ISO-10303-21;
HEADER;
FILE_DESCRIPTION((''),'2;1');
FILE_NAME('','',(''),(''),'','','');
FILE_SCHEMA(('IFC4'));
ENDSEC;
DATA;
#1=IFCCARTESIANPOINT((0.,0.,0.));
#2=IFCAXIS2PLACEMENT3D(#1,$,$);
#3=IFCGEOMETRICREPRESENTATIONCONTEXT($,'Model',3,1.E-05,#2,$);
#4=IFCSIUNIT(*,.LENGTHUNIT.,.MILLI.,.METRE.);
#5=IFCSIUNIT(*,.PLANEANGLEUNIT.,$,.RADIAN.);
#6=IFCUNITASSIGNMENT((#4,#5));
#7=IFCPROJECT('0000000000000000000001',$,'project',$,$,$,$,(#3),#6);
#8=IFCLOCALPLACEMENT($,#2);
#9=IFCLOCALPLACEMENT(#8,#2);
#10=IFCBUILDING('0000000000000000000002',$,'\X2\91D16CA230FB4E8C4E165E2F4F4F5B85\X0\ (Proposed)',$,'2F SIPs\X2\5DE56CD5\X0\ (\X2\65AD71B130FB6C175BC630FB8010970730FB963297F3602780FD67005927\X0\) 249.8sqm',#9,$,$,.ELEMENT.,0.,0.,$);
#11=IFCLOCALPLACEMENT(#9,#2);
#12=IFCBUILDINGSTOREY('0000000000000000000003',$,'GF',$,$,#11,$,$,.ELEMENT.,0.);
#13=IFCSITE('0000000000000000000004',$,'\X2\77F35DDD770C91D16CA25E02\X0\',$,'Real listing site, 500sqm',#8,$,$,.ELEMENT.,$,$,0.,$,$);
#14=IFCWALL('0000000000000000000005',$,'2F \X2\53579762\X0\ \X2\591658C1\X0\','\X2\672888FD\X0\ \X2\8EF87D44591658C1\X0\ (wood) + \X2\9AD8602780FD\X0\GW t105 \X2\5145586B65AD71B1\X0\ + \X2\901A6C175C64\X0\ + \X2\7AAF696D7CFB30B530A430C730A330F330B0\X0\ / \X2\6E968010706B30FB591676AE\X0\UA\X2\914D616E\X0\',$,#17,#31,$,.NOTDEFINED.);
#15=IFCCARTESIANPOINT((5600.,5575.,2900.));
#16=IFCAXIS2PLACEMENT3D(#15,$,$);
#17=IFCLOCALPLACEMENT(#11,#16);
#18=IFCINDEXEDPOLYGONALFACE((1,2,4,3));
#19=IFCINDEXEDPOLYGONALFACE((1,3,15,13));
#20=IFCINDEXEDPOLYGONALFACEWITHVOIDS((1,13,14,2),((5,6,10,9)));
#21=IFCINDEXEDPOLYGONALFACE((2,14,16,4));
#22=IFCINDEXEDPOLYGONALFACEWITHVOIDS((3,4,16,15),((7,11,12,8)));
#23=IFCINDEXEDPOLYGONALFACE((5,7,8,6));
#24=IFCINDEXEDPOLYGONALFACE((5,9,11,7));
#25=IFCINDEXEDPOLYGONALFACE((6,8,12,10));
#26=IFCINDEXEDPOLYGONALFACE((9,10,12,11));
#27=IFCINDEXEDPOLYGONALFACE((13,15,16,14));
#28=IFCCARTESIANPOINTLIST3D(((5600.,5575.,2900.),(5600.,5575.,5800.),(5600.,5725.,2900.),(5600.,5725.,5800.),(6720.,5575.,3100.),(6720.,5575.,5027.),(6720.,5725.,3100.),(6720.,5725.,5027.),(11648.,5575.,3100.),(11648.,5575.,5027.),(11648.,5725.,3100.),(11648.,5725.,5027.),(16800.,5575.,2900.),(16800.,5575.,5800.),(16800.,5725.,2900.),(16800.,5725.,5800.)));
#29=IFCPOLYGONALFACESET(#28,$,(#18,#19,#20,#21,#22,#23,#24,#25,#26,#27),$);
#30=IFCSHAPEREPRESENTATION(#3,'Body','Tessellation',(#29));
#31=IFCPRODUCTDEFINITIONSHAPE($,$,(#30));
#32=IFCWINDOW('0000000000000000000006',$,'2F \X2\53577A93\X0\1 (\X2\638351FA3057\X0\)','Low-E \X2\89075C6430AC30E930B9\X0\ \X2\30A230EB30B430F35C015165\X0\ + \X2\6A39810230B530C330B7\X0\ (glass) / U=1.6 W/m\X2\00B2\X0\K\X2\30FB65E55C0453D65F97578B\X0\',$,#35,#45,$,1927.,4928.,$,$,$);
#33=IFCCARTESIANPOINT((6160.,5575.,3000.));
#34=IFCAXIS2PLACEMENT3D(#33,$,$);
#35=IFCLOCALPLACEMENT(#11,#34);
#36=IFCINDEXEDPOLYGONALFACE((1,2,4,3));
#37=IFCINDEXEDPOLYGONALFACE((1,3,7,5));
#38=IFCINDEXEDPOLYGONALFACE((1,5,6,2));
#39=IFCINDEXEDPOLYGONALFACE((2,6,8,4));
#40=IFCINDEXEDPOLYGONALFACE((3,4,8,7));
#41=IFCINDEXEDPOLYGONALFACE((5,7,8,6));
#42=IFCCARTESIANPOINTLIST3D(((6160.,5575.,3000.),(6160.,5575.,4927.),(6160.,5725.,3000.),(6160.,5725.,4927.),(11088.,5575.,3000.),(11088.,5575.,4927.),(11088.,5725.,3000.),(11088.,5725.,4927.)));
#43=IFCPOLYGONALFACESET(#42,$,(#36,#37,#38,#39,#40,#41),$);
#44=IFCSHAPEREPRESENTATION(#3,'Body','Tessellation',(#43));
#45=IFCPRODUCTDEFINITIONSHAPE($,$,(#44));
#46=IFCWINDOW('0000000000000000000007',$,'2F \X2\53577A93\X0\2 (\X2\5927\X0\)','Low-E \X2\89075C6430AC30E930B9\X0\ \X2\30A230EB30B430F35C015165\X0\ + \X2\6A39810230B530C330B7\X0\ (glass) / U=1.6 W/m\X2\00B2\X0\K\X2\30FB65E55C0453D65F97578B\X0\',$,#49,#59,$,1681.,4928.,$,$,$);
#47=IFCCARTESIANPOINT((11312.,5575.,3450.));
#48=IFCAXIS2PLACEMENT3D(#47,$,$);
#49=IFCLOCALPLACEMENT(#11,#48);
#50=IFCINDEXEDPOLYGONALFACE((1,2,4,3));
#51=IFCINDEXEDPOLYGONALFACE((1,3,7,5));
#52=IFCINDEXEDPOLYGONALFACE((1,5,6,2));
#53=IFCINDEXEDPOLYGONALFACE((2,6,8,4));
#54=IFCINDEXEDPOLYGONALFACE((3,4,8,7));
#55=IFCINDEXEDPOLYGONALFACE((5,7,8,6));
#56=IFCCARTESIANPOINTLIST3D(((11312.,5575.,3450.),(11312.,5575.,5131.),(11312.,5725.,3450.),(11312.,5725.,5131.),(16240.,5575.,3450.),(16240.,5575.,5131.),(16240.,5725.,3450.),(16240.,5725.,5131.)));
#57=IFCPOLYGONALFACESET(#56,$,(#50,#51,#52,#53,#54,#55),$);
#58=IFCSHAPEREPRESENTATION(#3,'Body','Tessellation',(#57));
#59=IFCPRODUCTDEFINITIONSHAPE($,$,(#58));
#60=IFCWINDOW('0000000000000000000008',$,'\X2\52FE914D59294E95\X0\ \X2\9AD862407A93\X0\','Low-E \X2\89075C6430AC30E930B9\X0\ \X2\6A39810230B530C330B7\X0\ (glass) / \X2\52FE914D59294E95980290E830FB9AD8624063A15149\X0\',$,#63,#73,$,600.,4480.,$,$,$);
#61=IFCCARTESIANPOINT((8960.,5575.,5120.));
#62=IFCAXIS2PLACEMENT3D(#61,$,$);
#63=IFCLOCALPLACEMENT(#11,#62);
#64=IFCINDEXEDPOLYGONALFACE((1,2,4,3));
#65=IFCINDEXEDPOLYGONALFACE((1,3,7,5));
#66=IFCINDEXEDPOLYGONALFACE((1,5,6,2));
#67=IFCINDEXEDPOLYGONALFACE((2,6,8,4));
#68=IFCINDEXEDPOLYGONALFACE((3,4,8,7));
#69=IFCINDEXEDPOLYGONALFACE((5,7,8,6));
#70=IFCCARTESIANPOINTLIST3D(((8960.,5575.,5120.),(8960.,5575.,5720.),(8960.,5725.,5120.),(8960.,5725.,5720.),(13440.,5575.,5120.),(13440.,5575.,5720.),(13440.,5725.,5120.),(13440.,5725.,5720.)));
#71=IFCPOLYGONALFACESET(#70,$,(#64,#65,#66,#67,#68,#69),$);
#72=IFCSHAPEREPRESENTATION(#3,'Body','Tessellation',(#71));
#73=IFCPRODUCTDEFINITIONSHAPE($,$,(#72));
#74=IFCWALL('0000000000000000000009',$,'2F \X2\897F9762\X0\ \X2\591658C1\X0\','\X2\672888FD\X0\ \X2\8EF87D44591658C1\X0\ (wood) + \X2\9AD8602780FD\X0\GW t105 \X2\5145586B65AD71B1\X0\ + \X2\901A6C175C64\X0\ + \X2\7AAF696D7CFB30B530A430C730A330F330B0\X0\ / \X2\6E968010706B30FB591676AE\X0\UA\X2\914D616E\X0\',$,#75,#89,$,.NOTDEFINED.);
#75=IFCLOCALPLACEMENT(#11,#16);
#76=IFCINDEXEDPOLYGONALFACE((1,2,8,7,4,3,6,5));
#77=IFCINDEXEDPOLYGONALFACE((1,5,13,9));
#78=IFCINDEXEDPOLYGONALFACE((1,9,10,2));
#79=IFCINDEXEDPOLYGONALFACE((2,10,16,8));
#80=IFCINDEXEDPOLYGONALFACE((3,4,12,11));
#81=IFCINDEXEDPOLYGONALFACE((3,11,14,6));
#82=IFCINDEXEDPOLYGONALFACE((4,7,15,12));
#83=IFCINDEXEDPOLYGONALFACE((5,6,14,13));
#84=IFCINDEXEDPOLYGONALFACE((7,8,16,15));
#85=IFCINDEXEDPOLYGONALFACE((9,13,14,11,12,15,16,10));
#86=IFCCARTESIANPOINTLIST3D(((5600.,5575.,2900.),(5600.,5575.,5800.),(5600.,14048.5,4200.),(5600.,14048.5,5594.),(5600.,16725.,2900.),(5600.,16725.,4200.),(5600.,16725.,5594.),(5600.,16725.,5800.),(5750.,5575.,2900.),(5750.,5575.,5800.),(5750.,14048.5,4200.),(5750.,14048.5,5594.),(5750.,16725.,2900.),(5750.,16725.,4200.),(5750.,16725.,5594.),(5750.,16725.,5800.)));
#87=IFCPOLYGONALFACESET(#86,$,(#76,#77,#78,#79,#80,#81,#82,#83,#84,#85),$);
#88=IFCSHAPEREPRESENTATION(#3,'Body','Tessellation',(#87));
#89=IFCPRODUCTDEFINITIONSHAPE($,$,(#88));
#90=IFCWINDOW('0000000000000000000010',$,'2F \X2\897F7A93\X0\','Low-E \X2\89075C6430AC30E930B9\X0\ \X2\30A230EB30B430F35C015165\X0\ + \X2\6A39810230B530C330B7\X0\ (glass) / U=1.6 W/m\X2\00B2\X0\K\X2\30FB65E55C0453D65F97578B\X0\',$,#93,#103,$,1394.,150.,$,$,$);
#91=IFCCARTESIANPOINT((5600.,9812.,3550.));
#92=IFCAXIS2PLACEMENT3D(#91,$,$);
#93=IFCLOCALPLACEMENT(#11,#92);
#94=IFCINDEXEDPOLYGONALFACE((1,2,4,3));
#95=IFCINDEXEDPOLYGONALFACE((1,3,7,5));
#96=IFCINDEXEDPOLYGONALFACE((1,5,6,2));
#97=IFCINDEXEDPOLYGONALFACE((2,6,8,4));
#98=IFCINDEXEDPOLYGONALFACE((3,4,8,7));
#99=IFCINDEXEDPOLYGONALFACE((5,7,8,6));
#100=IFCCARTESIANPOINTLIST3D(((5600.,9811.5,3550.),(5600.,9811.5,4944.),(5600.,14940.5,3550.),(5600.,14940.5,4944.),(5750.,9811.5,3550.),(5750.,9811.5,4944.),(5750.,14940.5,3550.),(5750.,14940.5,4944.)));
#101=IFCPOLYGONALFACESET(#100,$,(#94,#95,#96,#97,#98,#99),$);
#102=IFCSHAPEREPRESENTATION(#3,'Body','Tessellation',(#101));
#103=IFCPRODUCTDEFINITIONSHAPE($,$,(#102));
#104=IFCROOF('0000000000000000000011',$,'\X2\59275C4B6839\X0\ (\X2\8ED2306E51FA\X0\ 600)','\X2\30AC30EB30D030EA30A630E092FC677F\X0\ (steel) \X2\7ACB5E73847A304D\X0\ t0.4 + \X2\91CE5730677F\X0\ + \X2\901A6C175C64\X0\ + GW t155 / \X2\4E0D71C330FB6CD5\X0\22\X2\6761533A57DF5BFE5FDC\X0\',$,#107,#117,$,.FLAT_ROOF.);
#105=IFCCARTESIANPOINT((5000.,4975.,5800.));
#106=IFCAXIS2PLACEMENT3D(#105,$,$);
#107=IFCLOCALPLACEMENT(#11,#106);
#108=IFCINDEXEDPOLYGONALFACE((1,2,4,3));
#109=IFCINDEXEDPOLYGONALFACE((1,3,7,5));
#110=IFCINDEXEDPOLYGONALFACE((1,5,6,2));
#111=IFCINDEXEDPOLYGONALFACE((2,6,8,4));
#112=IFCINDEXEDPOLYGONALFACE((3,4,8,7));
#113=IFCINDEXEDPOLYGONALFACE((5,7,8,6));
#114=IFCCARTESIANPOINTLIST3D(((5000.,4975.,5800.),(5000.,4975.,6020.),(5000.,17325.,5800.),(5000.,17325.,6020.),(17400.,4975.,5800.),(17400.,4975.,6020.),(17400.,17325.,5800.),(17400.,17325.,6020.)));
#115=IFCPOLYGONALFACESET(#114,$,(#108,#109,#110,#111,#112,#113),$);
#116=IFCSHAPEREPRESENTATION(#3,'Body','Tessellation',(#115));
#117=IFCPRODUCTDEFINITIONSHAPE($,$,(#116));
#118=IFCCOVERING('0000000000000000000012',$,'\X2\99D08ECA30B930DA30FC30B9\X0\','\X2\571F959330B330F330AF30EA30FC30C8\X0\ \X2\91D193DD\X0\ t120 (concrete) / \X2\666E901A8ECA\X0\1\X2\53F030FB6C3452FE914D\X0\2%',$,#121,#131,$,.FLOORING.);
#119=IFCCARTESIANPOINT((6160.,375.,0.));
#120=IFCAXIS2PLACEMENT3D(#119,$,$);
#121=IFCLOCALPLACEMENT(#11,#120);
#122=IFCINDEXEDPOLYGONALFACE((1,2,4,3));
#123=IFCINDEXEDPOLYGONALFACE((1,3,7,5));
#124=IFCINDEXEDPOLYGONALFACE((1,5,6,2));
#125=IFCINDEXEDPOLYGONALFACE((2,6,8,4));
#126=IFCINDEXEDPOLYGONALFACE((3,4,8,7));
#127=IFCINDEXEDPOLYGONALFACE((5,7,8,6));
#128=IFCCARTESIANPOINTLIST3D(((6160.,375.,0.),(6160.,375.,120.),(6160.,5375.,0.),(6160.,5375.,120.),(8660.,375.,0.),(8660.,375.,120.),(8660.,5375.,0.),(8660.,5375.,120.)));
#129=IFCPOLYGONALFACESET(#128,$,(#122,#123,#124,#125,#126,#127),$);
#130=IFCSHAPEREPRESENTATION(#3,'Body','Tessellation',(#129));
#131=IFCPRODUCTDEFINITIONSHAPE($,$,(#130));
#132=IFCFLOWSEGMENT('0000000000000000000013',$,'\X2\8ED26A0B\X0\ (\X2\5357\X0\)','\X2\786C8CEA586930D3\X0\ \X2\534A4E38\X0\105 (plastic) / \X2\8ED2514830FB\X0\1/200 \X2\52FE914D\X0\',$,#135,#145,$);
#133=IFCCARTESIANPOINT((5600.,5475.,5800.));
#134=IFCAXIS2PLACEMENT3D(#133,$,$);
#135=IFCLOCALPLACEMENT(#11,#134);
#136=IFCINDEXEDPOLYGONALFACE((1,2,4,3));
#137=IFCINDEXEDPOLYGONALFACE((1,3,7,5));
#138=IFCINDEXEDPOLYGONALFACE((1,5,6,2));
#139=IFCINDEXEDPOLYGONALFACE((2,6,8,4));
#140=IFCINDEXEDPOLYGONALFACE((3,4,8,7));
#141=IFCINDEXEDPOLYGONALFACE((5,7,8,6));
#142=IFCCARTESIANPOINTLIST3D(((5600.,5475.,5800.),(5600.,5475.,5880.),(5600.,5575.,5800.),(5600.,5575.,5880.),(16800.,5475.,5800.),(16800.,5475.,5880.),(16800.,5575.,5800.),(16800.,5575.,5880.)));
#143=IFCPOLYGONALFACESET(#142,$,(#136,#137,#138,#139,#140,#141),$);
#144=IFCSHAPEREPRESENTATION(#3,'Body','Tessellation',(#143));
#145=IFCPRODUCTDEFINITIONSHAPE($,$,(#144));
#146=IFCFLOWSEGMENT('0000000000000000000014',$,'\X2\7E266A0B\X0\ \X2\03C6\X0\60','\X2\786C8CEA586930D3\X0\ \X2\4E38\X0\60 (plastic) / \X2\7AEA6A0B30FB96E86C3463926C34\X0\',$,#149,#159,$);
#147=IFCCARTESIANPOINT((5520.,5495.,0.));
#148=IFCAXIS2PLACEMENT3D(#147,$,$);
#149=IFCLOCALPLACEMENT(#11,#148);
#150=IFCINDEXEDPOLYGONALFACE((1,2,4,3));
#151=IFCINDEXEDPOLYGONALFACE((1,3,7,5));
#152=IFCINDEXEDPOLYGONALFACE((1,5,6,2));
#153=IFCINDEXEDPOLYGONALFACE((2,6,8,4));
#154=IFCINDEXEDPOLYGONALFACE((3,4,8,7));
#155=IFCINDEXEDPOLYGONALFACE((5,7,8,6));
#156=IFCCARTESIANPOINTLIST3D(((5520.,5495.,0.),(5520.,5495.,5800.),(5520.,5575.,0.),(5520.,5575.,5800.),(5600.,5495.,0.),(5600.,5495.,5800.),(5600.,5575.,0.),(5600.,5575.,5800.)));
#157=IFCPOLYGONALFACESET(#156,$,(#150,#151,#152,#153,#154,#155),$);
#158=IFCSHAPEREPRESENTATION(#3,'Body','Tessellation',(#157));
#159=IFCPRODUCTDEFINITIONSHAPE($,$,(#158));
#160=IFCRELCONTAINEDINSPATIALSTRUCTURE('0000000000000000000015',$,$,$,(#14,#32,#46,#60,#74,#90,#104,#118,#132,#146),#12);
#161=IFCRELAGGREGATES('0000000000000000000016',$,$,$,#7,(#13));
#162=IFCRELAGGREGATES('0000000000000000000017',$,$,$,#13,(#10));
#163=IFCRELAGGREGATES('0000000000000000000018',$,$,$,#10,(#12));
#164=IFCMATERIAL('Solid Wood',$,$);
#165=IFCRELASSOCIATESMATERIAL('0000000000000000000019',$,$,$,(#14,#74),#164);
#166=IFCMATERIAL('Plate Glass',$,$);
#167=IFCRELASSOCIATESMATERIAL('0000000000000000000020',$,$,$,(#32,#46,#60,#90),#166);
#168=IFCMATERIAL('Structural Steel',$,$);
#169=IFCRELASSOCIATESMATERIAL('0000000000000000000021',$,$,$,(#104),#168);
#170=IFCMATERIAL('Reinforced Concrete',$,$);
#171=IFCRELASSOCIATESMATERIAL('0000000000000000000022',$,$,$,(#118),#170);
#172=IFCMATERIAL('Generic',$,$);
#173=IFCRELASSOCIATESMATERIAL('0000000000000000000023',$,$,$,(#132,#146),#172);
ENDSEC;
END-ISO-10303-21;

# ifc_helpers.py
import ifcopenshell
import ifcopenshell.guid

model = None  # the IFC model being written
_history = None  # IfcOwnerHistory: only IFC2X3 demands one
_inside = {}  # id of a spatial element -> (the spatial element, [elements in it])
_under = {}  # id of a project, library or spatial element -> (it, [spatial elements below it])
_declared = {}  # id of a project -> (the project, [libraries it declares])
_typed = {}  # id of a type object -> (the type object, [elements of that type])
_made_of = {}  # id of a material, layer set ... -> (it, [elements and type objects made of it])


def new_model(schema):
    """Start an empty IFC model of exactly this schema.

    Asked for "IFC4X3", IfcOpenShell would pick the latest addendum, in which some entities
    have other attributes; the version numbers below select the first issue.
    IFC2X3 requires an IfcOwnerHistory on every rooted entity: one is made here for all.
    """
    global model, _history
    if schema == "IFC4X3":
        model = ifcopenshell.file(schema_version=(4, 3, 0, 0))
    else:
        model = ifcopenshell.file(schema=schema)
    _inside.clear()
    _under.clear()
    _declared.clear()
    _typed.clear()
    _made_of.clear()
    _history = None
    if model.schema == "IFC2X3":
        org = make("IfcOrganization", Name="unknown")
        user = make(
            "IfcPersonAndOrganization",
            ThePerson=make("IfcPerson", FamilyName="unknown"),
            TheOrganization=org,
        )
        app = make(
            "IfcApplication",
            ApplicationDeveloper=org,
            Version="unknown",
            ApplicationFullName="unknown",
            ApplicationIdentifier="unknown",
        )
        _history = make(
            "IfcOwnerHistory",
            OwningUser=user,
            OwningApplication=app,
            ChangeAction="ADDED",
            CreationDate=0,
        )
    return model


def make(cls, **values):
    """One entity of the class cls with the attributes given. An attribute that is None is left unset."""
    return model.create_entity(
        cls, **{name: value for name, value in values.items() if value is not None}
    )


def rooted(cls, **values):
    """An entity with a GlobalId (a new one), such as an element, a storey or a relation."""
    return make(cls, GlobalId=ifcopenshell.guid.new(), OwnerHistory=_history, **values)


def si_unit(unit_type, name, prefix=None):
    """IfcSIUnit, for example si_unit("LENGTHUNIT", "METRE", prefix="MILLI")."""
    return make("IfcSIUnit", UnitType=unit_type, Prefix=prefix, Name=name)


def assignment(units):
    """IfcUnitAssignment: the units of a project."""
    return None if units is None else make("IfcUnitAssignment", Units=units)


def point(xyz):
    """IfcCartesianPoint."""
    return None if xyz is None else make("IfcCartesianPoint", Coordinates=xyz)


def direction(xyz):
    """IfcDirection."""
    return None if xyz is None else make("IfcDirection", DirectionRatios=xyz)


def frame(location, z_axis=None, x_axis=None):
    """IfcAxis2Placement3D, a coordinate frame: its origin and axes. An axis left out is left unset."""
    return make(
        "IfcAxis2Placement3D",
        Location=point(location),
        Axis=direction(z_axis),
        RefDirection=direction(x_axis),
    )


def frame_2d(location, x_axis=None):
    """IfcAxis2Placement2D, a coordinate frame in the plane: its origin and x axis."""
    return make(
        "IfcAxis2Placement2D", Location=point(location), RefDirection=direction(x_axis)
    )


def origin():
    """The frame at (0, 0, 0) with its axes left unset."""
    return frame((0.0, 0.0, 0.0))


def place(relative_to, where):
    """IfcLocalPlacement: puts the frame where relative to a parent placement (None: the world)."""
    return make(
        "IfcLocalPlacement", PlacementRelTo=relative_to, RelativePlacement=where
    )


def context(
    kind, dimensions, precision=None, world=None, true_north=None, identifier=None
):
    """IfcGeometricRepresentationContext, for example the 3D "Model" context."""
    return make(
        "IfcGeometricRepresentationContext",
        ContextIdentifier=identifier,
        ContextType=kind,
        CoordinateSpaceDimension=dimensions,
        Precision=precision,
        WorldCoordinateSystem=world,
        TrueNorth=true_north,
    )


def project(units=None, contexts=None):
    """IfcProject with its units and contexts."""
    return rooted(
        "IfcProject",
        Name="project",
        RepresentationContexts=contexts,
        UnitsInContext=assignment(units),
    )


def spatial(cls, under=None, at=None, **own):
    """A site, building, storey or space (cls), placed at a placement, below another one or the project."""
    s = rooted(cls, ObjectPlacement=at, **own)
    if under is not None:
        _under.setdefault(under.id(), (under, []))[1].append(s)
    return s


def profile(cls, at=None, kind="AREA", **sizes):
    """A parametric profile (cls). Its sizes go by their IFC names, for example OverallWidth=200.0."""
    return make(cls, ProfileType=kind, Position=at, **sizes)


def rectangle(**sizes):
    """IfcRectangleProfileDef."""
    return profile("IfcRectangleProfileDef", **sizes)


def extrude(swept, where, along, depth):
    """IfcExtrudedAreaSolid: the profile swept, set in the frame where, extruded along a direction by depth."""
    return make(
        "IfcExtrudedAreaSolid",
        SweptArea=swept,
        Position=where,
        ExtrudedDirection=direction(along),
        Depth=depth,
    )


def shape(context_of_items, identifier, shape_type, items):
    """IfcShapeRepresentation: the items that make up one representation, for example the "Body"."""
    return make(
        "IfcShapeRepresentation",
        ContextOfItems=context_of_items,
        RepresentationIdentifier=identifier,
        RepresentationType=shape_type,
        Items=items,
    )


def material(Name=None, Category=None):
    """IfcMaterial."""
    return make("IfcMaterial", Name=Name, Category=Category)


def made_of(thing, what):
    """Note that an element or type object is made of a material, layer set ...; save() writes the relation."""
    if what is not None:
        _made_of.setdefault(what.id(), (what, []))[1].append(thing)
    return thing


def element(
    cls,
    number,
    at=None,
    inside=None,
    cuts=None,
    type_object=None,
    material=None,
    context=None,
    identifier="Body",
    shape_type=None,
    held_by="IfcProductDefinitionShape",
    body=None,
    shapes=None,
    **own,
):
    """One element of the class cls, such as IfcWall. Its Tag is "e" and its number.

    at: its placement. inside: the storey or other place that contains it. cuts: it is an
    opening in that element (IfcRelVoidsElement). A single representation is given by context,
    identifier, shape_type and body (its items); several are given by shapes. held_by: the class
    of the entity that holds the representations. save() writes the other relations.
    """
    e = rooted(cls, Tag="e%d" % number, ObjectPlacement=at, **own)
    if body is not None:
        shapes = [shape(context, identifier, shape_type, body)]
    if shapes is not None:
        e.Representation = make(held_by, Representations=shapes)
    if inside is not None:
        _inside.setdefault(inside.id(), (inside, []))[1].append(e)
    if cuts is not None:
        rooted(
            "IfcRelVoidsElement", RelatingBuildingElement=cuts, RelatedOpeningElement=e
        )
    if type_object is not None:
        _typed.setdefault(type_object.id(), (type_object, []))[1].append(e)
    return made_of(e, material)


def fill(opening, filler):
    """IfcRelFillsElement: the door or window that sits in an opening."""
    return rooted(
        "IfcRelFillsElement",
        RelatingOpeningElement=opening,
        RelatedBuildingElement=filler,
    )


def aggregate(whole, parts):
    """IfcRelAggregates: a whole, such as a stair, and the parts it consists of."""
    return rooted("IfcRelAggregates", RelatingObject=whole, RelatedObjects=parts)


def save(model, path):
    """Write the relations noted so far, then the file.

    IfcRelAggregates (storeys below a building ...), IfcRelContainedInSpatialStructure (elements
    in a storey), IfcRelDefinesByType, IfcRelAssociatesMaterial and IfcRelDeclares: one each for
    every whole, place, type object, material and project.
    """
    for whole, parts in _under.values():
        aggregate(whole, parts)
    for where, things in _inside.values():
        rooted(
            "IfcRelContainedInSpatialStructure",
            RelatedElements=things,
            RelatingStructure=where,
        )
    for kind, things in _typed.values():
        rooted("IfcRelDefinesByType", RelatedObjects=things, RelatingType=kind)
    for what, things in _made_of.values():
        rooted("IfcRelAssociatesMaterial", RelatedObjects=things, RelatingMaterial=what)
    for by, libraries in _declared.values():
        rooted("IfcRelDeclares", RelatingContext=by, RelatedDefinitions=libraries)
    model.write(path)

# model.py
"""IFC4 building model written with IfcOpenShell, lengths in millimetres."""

from ifc_helpers import new_model, si_unit, frame, frame_2d, origin, place, context, project, spatial, rectangle, extrude, material, element, fill, save


model = new_model("IFC4")

# Units and contexts
model_context = context("Model", 3, precision=1e-05, world=origin())
ifc_project = project(units=[si_unit("LENGTHUNIT", "METRE", prefix="MILLI"), si_unit("PLANEANGLEUNIT", "RADIAN")], contexts=[model_context])

# Site, building, storey
site_placement = place(None, origin())
site = spatial("IfcSite", under=ifc_project, at=site_placement, Name="石川県金沢市", ObjectType="Real listing site, 500sqm", CompositionType="ELEMENT", RefElevation=0.0)
building_placement = place(site_placement, origin())
building = spatial("IfcBuilding", under=site, at=building_placement, Name="金沢・二世帯住宅 (Proposed)", ObjectType="2F SIPs工法 (断熱・気密・耐震・防音性能最大) 249.8sqm", CompositionType="ELEMENT", ElevationOfRefHeight=0.0, ElevationOfTerrain=0.0)
storey_placement = place(building_placement, origin())
storey = spatial("IfcBuildingStorey", under=building, at=storey_placement, Name="GF", CompositionType="ELEMENT", Elevation=0.0)

# Shared definitions
ifc_material_1 = material(Name="Solid Wood")

# Shared definitions
ifc_material_2 = material(Name="Reinforced Concrete")

# Shared definitions
ifc_material_3 = material(Name="Plate Glass")

# Wall, openings, windows
wall_1_placement = place(storey_placement, frame((5600.0, 5575.0, 2900.0)))
wall_1 = element("IfcWall", 1, at=wall_1_placement, inside=storey, material=ifc_material_1, Name="2F 南面 外壁", Description="木製 軸組外壁 (wood) + 高性能GW t105 充填断熱 + 通気層 + 窯業系サイディング / 準耐火・外皮UA配慮", PredefinedType="NOTDEFINED", context=model_context, shape_type="SweptSolid", body=[
    extrude(rectangle(XDim=11200.0, YDim=150.0, at=frame_2d((5600.0, 75.0))), frame((5600.0, 5575.0, 2900.0)), (0.0, 0.0, 1.0), 2900.0),
])
opening_1_placement = place(storey_placement, frame((6160.0, 5575.0, 3000.0)))
opening_1 = element("IfcOpeningElement", 2, at=opening_1_placement, cuts=wall_1, PredefinedType="NOTDEFINED", context=model_context, shape_type="SweptSolid", body=[
    extrude(rectangle(XDim=4928.0, YDim=150.0, at=frame_2d((2464.0, 75.0))), frame((6160.0, 5575.0, 3000.0)), (0.0, 0.0, 1.0), 1927.0),
])
opening_2_placement = place(storey_placement, frame((11312.0, 5575.0, 3450.0)))
opening_2 = element("IfcOpeningElement", 3, at=opening_2_placement, cuts=wall_1, PredefinedType="NOTDEFINED", context=model_context, shape_type="SweptSolid", body=[
    extrude(rectangle(XDim=4928.0, YDim=150.0, at=frame_2d((2464.0, 75.0))), frame((11312.0, 5575.0, 3450.0)), (0.0, 0.0, 1.0), 1681.0),
])
opening_3_placement = place(storey_placement, frame((8960.0, 5575.0, 5120.0)))
opening_3 = element("IfcOpeningElement", 4, at=opening_3_placement, cuts=wall_1, PredefinedType="NOTDEFINED", context=model_context, shape_type="SweptSolid", body=[
    extrude(rectangle(XDim=4480.0, YDim=150.0, at=frame_2d((2240.0, 75.0))), frame((8960.0, 5575.0, 5120.0)), (0.0, 0.0, 1.0), 600.0),
])
window_1_placement = place(storey_placement, frame((6160.0, 5575.0, 3000.0)))
window_1 = element("IfcWindow", 5, at=window_1_placement, inside=storey, material=ifc_material_3, Name="2F 南窓1 (掃出し)", Description="Low-E 複層ガラス アルゴン封入 + 樹脂サッシ (glass) / U=1.6 W/m²K・日射取得型", OverallHeight=1927.0, OverallWidth=4928.0, context=model_context, shape_type="SweptSolid", body=[
    extrude(rectangle(XDim=4928.0, YDim=150.0, at=frame_2d((2464.0, 75.0))), frame((6160.0, 5575.0, 3000.0)), (0.0, 0.0, 1.0), 1927.0),
])
fill(opening_1, window_1)
window_2_placement = place(storey_placement, frame((11312.0, 5575.0, 3450.0)))
window_2 = element("IfcWindow", 6, at=window_2_placement, inside=storey, material=ifc_material_3, Name="2F 南窓2 (大)", Description="Low-E 複層ガラス アルゴン封入 + 樹脂サッシ (glass) / U=1.6 W/m²K・日射取得型", OverallHeight=1681.0, OverallWidth=4928.0, context=model_context, shape_type="SweptSolid", body=[
    extrude(rectangle(XDim=4928.0, YDim=150.0, at=frame_2d((2464.0, 75.0))), frame((11312.0, 5575.0, 3450.0)), (0.0, 0.0, 1.0), 1681.0),
])
fill(opening_2, window_2)
window_3_placement = place(storey_placement, frame((8960.0, 5575.0, 5120.0)))
window_3 = element("IfcWindow", 7, at=window_3_placement, inside=storey, material=ifc_material_3, Name="勾配天井 高所窓", Description="Low-E 複層ガラス 樹脂サッシ (glass) / 勾配天井頂部・高所採光", OverallHeight=600.0, OverallWidth=4480.0, context=model_context, shape_type="SweptSolid", body=[
    extrude(rectangle(XDim=4480.0, YDim=150.0, at=frame_2d((2240.0, 75.0))), frame((8960.0, 5575.0, 5120.0)), (0.0, 0.0, 1.0), 600.0),
])
fill(opening_3, window_3)

# Wall, opening, window
wall_2_placement = place(storey_placement, frame((5600.0, 5575.0, 2900.0)))
wall_2 = element("IfcWall", 8, at=wall_2_placement, inside=storey, material=ifc_material_1, Name="2F 西面 外壁", Description="木製 軸組外壁 (wood) + 高性能GW t105 充填断熱 + 通気層 + 窯業系サイディング / 準耐火・外皮UA配慮", PredefinedType="NOTDEFINED", context=model_context, shape_type="SweptSolid", body=[
    extrude(rectangle(XDim=150.0, YDim=11150.0, at=frame_2d((75.0, 5575.0))), frame((5600.0, 5575.0, 2900.0)), (0.0, 0.0, 1.0), 2900.0),
])
opening_4_placement = place(storey_placement, frame((5600.0, 9812.0, 3550.0)))
opening_4 = element("IfcOpeningElement", 9, at=opening_4_placement, cuts=wall_2, PredefinedType="NOTDEFINED", context=model_context, shape_type="SweptSolid", body=[
    extrude(rectangle(XDim=150.0, YDim=5129.0, at=frame_2d((75.0, 2564.0))), frame((5600.0, 9812.0, 3550.0)), (0.0, 0.0, 1.0), 1394.0),
])
window_4_placement = place(storey_placement, frame((5600.0, 9812.0, 3550.0)))
window_4 = element("IfcWindow", 10, at=window_4_placement, inside=storey, material=ifc_material_3, Name="2F 西窓", Description="Low-E 複層ガラス アルゴン封入 + 樹脂サッシ (glass) / U=1.6 W/m²K・日射取得型", OverallHeight=1394.0, OverallWidth=150.0, context=model_context, shape_type="SweptSolid", body=[
    extrude(rectangle(XDim=150.0, YDim=5129.0, at=frame_2d((75.0, 2564.0))), frame((5600.0, 9812.0, 3550.0)), (0.0, 0.0, 1.0), 1394.0),
])
fill(opening_4, window_4)

# Roof
ifc_material_4 = material(Name="Structural Steel")
roof_placement = place(storey_placement, frame((5000.0, 4975.0, 5800.0)))
element("IfcRoof", 11, at=roof_placement, inside=storey, material=ifc_material_4, Name="大屋根 (軒の出 600)", Description="ガルバリウム鋼板 (steel) 立平葺き t0.4 + 野地板 + 通気層 + GW t155 / 不燃・法22条区域対応", PredefinedType="FLAT_ROOF", context=model_context, shape_type="SweptSolid", body=[
    extrude(rectangle(XDim=12400.0, YDim=12350.0, at=frame_2d((6200.0, 6175.0))), frame((5000.0, 4975.0, 5800.0)), (0.0, 0.0, 1.0), 220.0),
])

# Covering
covering_placement = place(storey_placement, frame((6160.0, 375.0, 0.0)))
element("IfcCovering", 12, at=covering_placement, inside=storey, material=ifc_material_2, Name="駐車スペース", Description="土間コンクリート 金鏝 t120 (concrete) / 普通車1台・水勾配2%", PredefinedType="FLOORING", context=model_context, shape_type="SweptSolid", body=[
    extrude(rectangle(XDim=2500.0, YDim=5000.0, at=frame_2d((1250.0, 2500.0))), frame((6160.0, 375.0, 0.0)), (0.0, 0.0, 1.0), 120.0),
])

# Flow segments
ifc_material_5 = material(Name="Generic")
flow_segment_1_placement = place(storey_placement, frame((5600.0, 5475.0, 5800.0)))
element("IfcFlowSegment", 13, at=flow_segment_1_placement, inside=storey, material=ifc_material_5, Name="軒樋 (南)", Description="硬質塩ビ 半丸105 (plastic) / 軒先・1/200 勾配", context=model_context, shape_type="SweptSolid", body=[
    extrude(rectangle(XDim=11200.0, YDim=100.0, at=frame_2d((5600.0, 50.0))), frame((5600.0, 5475.0, 5800.0)), (0.0, 0.0, 1.0), 80.0),
])
flow_segment_2_placement = place(storey_placement, frame((5520.0, 5495.0, 0.0)))
element("IfcFlowSegment", 14, at=flow_segment_2_placement, inside=storey, material=ifc_material_5, Name="縦樋 φ60", Description="硬質塩ビ 丸60 (plastic) / 竪樋・雨水排水", context=model_context, shape_type="SweptSolid", body=[
    extrude(rectangle(XDim=80.0, YDim=80.0, at=frame_2d((40.0, 40.0))), frame((5520.0, 5495.0, 0.0)), (0.0, 0.0, 1.0), 5800.0),
])

save(model, "model.ifc")
